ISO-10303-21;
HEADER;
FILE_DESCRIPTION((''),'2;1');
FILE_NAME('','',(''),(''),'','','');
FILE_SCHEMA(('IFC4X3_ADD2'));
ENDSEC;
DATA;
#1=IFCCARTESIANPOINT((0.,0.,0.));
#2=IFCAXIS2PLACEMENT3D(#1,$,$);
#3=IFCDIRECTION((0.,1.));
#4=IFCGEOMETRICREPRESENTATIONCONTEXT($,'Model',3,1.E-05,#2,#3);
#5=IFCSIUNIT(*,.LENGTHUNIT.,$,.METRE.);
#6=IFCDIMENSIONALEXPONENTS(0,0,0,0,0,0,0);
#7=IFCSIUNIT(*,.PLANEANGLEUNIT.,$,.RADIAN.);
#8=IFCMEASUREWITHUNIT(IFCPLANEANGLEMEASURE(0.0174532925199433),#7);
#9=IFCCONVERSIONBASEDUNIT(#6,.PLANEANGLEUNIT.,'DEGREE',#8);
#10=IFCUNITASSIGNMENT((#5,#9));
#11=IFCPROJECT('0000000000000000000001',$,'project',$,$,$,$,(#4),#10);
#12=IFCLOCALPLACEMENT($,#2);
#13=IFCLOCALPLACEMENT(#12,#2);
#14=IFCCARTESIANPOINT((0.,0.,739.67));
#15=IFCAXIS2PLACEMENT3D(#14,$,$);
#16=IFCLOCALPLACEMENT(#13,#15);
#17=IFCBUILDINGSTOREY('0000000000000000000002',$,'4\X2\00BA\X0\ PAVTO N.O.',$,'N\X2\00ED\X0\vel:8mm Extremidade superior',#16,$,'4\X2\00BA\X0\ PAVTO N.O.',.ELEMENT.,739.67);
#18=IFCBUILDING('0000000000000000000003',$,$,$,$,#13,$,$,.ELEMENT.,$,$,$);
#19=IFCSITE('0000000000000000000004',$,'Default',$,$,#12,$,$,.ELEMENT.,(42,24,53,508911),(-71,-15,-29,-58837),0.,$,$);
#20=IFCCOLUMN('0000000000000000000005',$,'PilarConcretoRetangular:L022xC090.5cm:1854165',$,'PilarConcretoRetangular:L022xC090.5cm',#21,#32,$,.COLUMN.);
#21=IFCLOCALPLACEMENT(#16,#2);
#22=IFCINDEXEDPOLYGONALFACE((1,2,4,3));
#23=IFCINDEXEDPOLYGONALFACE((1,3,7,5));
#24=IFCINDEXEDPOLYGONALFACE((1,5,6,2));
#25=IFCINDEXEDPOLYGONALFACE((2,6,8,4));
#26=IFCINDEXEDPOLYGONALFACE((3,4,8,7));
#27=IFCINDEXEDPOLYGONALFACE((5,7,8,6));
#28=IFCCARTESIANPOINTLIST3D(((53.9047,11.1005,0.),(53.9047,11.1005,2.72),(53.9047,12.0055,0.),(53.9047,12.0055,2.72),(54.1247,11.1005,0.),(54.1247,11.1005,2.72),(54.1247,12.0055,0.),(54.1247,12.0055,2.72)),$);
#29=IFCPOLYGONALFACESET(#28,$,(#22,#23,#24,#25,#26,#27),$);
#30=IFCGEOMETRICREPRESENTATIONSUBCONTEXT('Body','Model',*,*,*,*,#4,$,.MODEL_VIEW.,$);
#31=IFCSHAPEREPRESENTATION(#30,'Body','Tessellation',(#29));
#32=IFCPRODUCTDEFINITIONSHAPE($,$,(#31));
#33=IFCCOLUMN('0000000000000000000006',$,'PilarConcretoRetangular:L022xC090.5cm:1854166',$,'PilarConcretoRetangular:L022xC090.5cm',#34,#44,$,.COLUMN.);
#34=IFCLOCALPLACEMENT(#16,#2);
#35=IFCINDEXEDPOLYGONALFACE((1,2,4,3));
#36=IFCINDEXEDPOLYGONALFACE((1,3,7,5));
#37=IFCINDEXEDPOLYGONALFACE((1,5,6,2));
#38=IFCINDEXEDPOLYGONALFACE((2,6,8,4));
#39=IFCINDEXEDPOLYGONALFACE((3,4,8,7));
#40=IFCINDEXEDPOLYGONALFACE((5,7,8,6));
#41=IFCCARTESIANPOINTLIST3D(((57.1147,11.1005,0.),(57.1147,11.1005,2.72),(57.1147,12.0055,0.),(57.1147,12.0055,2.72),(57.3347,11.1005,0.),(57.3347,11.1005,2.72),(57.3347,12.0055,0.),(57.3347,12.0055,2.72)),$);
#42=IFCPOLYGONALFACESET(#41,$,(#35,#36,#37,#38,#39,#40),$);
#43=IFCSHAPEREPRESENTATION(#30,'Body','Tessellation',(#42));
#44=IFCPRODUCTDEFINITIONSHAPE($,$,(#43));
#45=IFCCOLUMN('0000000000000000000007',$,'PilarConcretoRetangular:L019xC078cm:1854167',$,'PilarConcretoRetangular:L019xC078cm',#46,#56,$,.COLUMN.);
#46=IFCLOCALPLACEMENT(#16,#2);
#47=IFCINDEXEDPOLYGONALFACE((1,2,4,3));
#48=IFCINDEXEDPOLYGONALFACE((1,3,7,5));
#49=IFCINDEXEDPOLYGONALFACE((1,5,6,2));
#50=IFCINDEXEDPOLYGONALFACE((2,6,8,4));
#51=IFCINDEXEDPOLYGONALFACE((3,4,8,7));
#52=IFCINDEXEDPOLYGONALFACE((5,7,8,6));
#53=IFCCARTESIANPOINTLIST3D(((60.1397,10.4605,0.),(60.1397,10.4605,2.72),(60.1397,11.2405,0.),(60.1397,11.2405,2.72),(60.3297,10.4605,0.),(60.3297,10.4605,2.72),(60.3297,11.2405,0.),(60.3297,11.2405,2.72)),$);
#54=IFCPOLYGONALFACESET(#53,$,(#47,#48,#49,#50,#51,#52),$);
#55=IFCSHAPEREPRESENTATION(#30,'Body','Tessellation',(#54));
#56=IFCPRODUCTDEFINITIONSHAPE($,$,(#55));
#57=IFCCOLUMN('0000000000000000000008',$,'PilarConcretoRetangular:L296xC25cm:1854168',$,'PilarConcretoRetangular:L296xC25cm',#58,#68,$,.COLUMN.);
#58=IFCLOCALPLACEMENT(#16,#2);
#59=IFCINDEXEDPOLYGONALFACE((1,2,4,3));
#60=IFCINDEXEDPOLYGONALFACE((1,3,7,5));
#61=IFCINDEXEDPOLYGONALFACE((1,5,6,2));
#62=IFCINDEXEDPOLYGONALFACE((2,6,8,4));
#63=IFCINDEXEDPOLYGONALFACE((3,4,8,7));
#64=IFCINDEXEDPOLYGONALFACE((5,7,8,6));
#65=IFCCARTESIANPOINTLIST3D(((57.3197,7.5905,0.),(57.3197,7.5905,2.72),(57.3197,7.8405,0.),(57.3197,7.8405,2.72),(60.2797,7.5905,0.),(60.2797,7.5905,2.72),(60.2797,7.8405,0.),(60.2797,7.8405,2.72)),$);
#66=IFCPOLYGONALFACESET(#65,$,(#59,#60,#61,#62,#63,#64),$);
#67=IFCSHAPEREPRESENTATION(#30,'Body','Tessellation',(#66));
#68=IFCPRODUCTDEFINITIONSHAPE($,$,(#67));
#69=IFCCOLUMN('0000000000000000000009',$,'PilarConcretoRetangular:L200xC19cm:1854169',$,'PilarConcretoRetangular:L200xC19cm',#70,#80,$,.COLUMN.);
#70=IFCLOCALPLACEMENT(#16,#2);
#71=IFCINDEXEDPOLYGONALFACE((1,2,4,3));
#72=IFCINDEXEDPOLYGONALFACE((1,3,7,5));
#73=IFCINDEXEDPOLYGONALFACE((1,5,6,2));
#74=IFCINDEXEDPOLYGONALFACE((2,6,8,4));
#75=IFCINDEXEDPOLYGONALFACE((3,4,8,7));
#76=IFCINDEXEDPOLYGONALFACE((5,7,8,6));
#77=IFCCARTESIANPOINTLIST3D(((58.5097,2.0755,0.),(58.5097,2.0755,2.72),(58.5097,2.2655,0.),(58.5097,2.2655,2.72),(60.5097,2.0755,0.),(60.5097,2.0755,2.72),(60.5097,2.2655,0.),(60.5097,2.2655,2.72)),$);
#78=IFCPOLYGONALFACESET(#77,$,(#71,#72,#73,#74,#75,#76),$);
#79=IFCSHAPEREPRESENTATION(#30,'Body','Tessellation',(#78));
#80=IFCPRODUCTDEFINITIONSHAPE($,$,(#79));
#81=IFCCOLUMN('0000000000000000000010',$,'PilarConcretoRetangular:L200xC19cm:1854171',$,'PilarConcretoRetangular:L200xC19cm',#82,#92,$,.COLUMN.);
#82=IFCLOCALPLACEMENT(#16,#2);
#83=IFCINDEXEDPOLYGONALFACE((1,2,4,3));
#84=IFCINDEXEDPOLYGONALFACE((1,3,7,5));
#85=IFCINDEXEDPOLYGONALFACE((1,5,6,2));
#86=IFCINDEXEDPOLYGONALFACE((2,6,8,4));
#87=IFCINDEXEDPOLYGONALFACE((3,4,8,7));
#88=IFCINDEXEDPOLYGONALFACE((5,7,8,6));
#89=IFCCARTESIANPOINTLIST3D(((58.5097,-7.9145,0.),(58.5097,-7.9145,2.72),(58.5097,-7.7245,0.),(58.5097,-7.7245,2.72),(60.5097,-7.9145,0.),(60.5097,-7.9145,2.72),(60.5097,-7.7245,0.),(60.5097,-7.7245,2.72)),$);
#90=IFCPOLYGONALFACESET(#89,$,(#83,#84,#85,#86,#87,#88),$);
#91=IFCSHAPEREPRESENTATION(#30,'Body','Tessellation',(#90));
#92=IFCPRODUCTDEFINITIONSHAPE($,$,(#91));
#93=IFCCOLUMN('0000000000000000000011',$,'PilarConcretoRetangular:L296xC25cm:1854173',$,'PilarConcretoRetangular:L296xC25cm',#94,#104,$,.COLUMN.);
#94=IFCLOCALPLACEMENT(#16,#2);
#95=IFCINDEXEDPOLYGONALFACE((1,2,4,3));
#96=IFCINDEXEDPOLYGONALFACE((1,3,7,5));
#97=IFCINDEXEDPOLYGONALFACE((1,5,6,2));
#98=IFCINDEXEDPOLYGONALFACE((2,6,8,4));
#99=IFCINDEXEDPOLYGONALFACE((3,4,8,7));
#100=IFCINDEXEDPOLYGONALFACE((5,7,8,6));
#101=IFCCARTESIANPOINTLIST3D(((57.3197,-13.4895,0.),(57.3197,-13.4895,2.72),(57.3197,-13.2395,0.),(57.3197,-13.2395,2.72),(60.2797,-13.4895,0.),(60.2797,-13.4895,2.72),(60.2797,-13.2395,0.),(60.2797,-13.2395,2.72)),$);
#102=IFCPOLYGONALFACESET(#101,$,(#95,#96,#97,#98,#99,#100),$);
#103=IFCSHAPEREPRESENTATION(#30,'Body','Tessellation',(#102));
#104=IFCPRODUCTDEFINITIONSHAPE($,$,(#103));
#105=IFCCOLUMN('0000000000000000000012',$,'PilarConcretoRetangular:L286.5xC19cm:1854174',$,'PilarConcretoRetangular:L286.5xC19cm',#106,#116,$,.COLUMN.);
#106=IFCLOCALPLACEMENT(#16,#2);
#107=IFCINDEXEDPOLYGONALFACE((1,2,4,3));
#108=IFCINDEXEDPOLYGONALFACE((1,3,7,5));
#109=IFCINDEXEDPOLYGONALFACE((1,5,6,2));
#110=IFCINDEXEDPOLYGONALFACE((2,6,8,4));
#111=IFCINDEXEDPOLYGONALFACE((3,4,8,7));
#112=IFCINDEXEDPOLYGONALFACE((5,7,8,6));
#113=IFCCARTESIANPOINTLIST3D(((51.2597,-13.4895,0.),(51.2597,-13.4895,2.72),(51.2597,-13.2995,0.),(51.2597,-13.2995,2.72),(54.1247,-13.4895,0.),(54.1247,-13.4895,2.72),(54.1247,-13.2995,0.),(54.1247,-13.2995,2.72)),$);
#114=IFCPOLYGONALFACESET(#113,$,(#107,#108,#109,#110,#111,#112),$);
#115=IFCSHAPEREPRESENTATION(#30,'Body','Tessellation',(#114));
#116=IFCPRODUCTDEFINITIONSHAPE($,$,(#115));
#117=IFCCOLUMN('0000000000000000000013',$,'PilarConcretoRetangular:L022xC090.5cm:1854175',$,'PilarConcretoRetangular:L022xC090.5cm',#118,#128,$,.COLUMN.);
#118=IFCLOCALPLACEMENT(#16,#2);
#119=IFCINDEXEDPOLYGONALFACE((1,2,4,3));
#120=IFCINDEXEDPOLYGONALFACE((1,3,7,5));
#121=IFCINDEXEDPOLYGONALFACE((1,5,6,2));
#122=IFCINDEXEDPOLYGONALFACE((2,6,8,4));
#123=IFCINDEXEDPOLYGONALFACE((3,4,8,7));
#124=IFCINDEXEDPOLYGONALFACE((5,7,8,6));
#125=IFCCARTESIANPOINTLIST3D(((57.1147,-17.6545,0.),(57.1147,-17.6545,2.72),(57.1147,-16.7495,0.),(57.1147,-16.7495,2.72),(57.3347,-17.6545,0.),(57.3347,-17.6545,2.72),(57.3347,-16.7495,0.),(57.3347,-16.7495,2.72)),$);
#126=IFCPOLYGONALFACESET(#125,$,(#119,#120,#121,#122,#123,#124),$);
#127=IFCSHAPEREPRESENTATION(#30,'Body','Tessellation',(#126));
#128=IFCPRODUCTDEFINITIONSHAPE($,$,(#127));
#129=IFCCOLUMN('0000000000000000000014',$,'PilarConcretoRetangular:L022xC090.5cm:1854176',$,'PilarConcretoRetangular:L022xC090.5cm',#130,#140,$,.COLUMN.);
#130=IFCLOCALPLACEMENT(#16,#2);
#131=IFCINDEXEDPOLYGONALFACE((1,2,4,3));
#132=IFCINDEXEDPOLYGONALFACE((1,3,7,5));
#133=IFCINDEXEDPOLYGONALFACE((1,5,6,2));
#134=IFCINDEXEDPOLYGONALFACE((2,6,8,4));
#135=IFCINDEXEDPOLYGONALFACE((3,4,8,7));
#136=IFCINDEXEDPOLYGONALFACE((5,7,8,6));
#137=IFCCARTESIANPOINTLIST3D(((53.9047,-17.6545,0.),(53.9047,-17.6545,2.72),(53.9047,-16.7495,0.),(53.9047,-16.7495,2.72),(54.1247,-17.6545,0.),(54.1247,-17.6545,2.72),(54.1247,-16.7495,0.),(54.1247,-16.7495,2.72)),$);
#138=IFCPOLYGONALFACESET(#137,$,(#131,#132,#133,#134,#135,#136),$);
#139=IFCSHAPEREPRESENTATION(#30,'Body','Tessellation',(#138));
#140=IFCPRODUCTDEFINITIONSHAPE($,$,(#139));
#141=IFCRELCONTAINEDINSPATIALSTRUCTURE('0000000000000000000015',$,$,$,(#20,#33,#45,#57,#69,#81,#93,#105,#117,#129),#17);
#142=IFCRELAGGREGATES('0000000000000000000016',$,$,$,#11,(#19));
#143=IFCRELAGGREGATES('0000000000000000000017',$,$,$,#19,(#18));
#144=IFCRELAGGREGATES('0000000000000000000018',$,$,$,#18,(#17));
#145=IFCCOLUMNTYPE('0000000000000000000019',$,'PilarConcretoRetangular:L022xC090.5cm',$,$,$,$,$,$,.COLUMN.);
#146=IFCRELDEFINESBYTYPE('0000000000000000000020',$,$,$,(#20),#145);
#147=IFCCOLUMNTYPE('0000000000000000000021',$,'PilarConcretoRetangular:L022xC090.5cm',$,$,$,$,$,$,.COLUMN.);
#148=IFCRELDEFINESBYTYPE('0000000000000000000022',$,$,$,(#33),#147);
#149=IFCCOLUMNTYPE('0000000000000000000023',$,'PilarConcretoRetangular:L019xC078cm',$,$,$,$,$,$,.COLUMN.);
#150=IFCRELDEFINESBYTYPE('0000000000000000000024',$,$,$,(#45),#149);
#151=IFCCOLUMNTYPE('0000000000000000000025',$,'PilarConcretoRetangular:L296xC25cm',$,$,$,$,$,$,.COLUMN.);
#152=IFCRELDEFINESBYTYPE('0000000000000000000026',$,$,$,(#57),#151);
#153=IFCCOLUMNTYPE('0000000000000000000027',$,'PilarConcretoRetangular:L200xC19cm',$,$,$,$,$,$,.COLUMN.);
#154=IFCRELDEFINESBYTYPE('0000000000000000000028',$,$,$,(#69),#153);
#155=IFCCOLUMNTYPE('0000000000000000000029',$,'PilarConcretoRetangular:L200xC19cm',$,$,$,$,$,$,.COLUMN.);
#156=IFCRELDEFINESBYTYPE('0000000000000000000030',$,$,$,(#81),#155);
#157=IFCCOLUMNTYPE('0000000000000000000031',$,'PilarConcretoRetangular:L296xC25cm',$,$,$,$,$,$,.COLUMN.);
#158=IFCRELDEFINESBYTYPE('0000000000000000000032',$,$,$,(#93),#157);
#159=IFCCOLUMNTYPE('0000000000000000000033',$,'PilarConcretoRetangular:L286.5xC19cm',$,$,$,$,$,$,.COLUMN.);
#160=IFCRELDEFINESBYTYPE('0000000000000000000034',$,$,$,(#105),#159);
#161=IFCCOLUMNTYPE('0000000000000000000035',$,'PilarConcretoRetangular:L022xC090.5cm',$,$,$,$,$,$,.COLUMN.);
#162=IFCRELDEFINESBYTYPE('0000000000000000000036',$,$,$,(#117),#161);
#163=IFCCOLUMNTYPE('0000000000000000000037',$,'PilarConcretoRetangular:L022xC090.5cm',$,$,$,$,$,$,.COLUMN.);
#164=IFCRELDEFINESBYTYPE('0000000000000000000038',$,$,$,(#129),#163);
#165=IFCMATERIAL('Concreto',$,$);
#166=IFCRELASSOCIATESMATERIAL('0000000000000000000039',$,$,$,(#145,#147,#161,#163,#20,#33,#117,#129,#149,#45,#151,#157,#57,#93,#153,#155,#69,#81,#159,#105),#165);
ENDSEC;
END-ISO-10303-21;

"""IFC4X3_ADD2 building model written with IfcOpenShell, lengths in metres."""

from ifc_helpers import new_model, entity, si_unit, converted_unit, direction, frame, frame_2d, origin, origin_2d_with_axis, place, context, subcontext, project, spatial, rectangle, extrude, source, transform, mapped, material, material_profile, profile_set, profile_usage, type_object, type_shapes, element, save


model = new_model("IFC4X3_ADD2")

# Units and contexts
model_context = context("Model", 3, precision=1e-05, world=origin(), true_north=direction((0.0, 1.0)))
body_context = subcontext(model_context, "Body", "Model", "MODEL_VIEW")
ifc_project = project(units=[si_unit("LENGTHUNIT", "METRE"), converted_unit("PLANEANGLEUNIT", "DEGREE", entity("IfcPlaneAngleMeasure", 0.0174532925199433), si_unit("PLANEANGLEUNIT", "RADIAN"), dimensions=[0, 0, 0, 0, 0, 0, 0])], contexts=[model_context])

# Site, building, storey
site_placement = place(None, origin())
site = spatial("IfcSite", under=ifc_project, at=site_placement, Name="Default", CompositionType="ELEMENT", RefLatitude=(42, 24, 53, 508911), RefLongitude=(-71, -15, -29, -58837), RefElevation=0.0)
building_placement = place(site_placement, origin())
building = spatial("IfcBuilding", under=site, at=building_placement, CompositionType="ELEMENT")
storey_placement = place(building_placement, frame((0.0, 0.0, 739.67)))
storey = spatial("IfcBuildingStorey", under=building, at=storey_placement, Name="4º PAVTO N.O.", ObjectType="Nível:8mm Extremidade superior", LongName="4º PAVTO N.O.", CompositionType="ELEMENT", Elevation=739.67)

# Columns
ifc_material = material(Name="Concreto")
ifc_material_profile_1 = material_profile(ifc_material, rectangle(XDim=0.22, YDim=0.905, at=frame_2d((0.0, 0.0), x_axis=(1.0, 0.0))), Name="L022xC090.5cm")
ifc_profile_set_1 = profile_set([ifc_material_profile_1], Name="L022xC090.5cm")
ifc_profile_usage_1 = profile_usage(ifc_profile_set_1)
ifc_material_profile_2 = material_profile(ifc_material, rectangle(XDim=2.0, YDim=0.19, at=frame_2d((0.0, 0.0), x_axis=(1.0, 0.0))), Name="L200xC19cm")
ifc_profile_set_2 = profile_set([ifc_material_profile_2], Name="L200xC19cm")
ifc_profile_usage_2 = profile_usage(ifc_profile_set_2)
ifc_material_profile_3 = material_profile(ifc_material, rectangle(XDim=2.96, YDim=0.25, at=frame_2d((0.0, 0.0), x_axis=(1.0, 0.0))), Name="L296xC25cm")
ifc_profile_set_3 = profile_set([ifc_material_profile_3], Name="L296xC25cm")
ifc_profile_usage_3 = profile_usage(ifc_profile_set_3)
ifc_material_profile_4 = material_profile(ifc_material, rectangle(XDim=2.865, YDim=0.19, at=frame_2d((0.0, 0.0), x_axis=(1.0, 0.0))), Name="L286.5xC19cm")
ifc_profile_set_4 = profile_set([ifc_material_profile_4], Name="L286.5xC19cm")
ifc_profile_usage_4 = profile_usage(ifc_profile_set_4)
column_type_1 = type_object("IfcColumnType", Name="PilarConcretoRetangular:L022xC090.5cm", PredefinedType="COLUMN", material=ifc_profile_set_1)
shared_shape_1 = source(origin(), body_context, "Body", "SweptSolid", [
    extrude(rectangle(XDim=0.22, YDim=0.905, at=frame_2d((0.0, 0.0), x_axis=(1.0, 0.0))), frame((54.0147, 11.553, 739.67)), (0.0, 0.0, 1.0), 2.72),
])
type_shapes(column_type_1, [shared_shape_1])
column_1_placement = place(storey_placement, frame((0.0, 0.0, -739.67)))
element("IfcColumn", 1, at=column_1_placement, inside=storey, type_object=column_type_1, material=ifc_profile_usage_1, Name="PilarConcretoRetangular:L022xC090.5cm:1854165", ObjectType="PilarConcretoRetangular:L022xC090.5cm", PredefinedType="COLUMN", context=body_context, shape_type="MappedRepresentation", body=[
    mapped(shared_shape_1, transform((0.0, 0.0, 0.0), scale=1.0)),
])
column_type_2 = type_object("IfcColumnType", Name="PilarConcretoRetangular:L022xC090.5cm", PredefinedType="COLUMN", material=ifc_profile_set_1)
shared_shape_2 = source(origin(), body_context, "Body", "SweptSolid", [
    extrude(rectangle(XDim=0.22, YDim=0.905, at=frame_2d((0.0, 0.0), x_axis=(1.0, 0.0))), frame((57.2247, 11.553, 739.67)), (0.0, 0.0, 1.0), 2.72),
])
type_shapes(column_type_2, [shared_shape_2])
column_2_placement = place(storey_placement, frame((0.0, 0.0, -739.67)))
element("IfcColumn", 2, at=column_2_placement, inside=storey, type_object=column_type_2, material=ifc_profile_usage_1, Name="PilarConcretoRetangular:L022xC090.5cm:1854166", ObjectType="PilarConcretoRetangular:L022xC090.5cm", PredefinedType="COLUMN", context=body_context, shape_type="MappedRepresentation", body=[
    mapped(shared_shape_2, transform((0.0, 0.0, 0.0), scale=1.0)),
])
ifc_material_profile_5 = material_profile(ifc_material, rectangle(XDim=0.19, YDim=0.78, at=frame_2d((0.0, 0.0), x_axis=(1.0, 0.0))), Name="L019xC078cm")
ifc_profile_set_5 = profile_set([ifc_material_profile_5], Name="L019xC078cm")
ifc_profile_usage_5 = profile_usage(ifc_profile_set_5)
column_type_3 = type_object("IfcColumnType", Name="PilarConcretoRetangular:L019xC078cm", PredefinedType="COLUMN", material=ifc_profile_set_5)
shared_shape_3 = source(origin(), body_context, "Body", "SweptSolid", [
    extrude(rectangle(XDim=0.19, YDim=0.78, at=frame_2d((0.0, 0.0), x_axis=(1.0, 0.0))), frame((60.2347, 10.8505, 739.67)), (0.0, 0.0, 1.0), 2.72),
])
type_shapes(column_type_3, [shared_shape_3])
column_3_placement = place(storey_placement, frame((0.0, 0.0, -739.67)))
element("IfcColumn", 3, at=column_3_placement, inside=storey, type_object=column_type_3, material=ifc_profile_usage_5, Name="PilarConcretoRetangular:L019xC078cm:1854167", ObjectType="PilarConcretoRetangular:L019xC078cm", PredefinedType="COLUMN", context=body_context, shape_type="MappedRepresentation", body=[
    mapped(shared_shape_3, transform((0.0, 0.0, 0.0), scale=1.0)),
])
column_type_4 = type_object("IfcColumnType", Name="PilarConcretoRetangular:L296xC25cm", PredefinedType="COLUMN", material=ifc_profile_set_3)
shared_shape_4 = source(origin(), body_context, "Body", "SweptSolid", [
    extrude(rectangle(XDim=2.96, YDim=0.25, at=frame_2d((0.0, 0.0), x_axis=(1.0, 0.0))), frame((58.7997, 7.7155, 739.67), z_axis=(0.0, 0.0, 1.0), x_axis=(-1.0, 0.0, 0.0)), (0.0, 0.0, 1.0), 2.72),
])
type_shapes(column_type_4, [shared_shape_4])
column_4_placement = place(storey_placement, frame((0.0, 0.0, -739.67)))
element("IfcColumn", 4, at=column_4_placement, inside=storey, type_object=column_type_4, material=ifc_profile_usage_3, Name="PilarConcretoRetangular:L296xC25cm:1854168", ObjectType="PilarConcretoRetangular:L296xC25cm", PredefinedType="COLUMN", context=body_context, shape_type="MappedRepresentation", body=[
    mapped(shared_shape_4, transform((0.0, 0.0, 0.0), scale=1.0)),
])
column_type_5 = type_object("IfcColumnType", Name="PilarConcretoRetangular:L200xC19cm", PredefinedType="COLUMN", material=ifc_profile_set_2)
shared_shape_5 = source(origin(), body_context, "Body", "SweptSolid", [
    extrude(rectangle(XDim=2.0, YDim=0.19, at=origin_2d_with_axis()), frame((59.5097, 2.1705, 739.67), z_axis=(0.0, 0.0, 1.0), x_axis=(-1.0, 0.0, 0.0)), (0.0, 0.0, 1.0), 2.72),
])
type_shapes(column_type_5, [shared_shape_5])
column_5_placement = place(storey_placement, frame((0.0, 0.0, -739.67)))
element("IfcColumn", 5, at=column_5_placement, inside=storey, type_object=column_type_5, material=ifc_profile_usage_2, Name="PilarConcretoRetangular:L200xC19cm:1854169", ObjectType="PilarConcretoRetangular:L200xC19cm", PredefinedType="COLUMN", context=body_context, shape_type="MappedRepresentation", body=[
    mapped(shared_shape_5, transform((0.0, 0.0, 0.0), scale=1.0)),
])
column_type_6 = type_object("IfcColumnType", Name="PilarConcretoRetangular:L200xC19cm", PredefinedType="COLUMN", material=ifc_profile_set_2)
shared_shape_6 = source(origin(), body_context, "Body", "SweptSolid", [
    extrude(rectangle(XDim=2.0, YDim=0.19, at=origin_2d_with_axis()), frame((59.5097, -7.8195, 739.67), z_axis=(0.0, 0.0, 1.0), x_axis=(-1.0, 0.0, 0.0)), (0.0, 0.0, 1.0), 2.72),
])
type_shapes(column_type_6, [shared_shape_6])
column_6_placement = place(storey_placement, frame((0.0, 0.0, -739.67)))
element("IfcColumn", 6, at=column_6_placement, inside=storey, type_object=column_type_6, material=ifc_profile_usage_2, Name="PilarConcretoRetangular:L200xC19cm:1854171", ObjectType="PilarConcretoRetangular:L200xC19cm", PredefinedType="COLUMN", context=body_context, shape_type="MappedRepresentation", body=[
    mapped(shared_shape_6, transform((0.0, 0.0, 0.0), scale=1.0)),
])
column_type_7 = type_object("IfcColumnType", Name="PilarConcretoRetangular:L296xC25cm", PredefinedType="COLUMN", material=ifc_profile_set_3)
shared_shape_7 = source(origin(), body_context, "Body", "SweptSolid", [
    extrude(rectangle(XDim=2.96, YDim=0.25, at=frame_2d((0.0, 0.0), x_axis=(1.0, 0.0))), frame((58.7997, -13.3645, 739.67), z_axis=(0.0, 0.0, 1.0), x_axis=(-1.0, 0.0, 0.0)), (0.0, 0.0, 1.0), 2.72),
])
type_shapes(column_type_7, [shared_shape_7])
column_7_placement = place(storey_placement, frame((0.0, 0.0, -739.67)))
element("IfcColumn", 7, at=column_7_placement, inside=storey, type_object=column_type_7, material=ifc_profile_usage_3, Name="PilarConcretoRetangular:L296xC25cm:1854173", ObjectType="PilarConcretoRetangular:L296xC25cm", PredefinedType="COLUMN", context=body_context, shape_type="MappedRepresentation", body=[
    mapped(shared_shape_7, transform((0.0, 0.0, 0.0), scale=1.0)),
])
column_type_8 = type_object("IfcColumnType", Name="PilarConcretoRetangular:L286.5xC19cm", PredefinedType="COLUMN", material=ifc_profile_set_4)
shared_shape_8 = source(origin(), body_context, "Body", "SweptSolid", [
    extrude(rectangle(XDim=2.865, YDim=0.19, at=frame_2d((0.0, 0.0), x_axis=(1.0, 0.0))), frame((52.6922, -13.3945, 739.67), z_axis=(0.0, 0.0, 1.0), x_axis=(-1.0, 0.0, 0.0)), (0.0, 0.0, 1.0), 2.72),
])
type_shapes(column_type_8, [shared_shape_8])
column_8_placement = place(storey_placement, frame((0.0, 0.0, -739.67)))
element("IfcColumn", 8, at=column_8_placement, inside=storey, type_object=column_type_8, material=ifc_profile_usage_4, Name="PilarConcretoRetangular:L286.5xC19cm:1854174", ObjectType="PilarConcretoRetangular:L286.5xC19cm", PredefinedType="COLUMN", context=body_context, shape_type="MappedRepresentation", body=[
    mapped(shared_shape_8, transform((0.0, 0.0, 0.0), scale=1.0)),
])
column_type_9 = type_object("IfcColumnType", Name="PilarConcretoRetangular:L022xC090.5cm", PredefinedType="COLUMN", material=ifc_profile_set_1)
shared_shape_9 = source(origin(), body_context, "Body", "SweptSolid", [
    extrude(rectangle(XDim=0.22, YDim=0.905, at=frame_2d((0.0, 0.0), x_axis=(1.0, 0.0))), frame((57.2247, -17.202, 739.67), z_axis=(0.0, 0.0, 1.0), x_axis=(-1.0, 0.0, 0.0)), (0.0, 0.0, 1.0), 2.72),
])
type_shapes(column_type_9, [shared_shape_9])
column_9_placement = place(storey_placement, frame((0.0, 0.0, -739.67)))
element("IfcColumn", 9, at=column_9_placement, inside=storey, type_object=column_type_9, material=ifc_profile_usage_1, Name="PilarConcretoRetangular:L022xC090.5cm:1854175", ObjectType="PilarConcretoRetangular:L022xC090.5cm", PredefinedType="COLUMN", context=body_context, shape_type="MappedRepresentation", body=[
    mapped(shared_shape_9, transform((0.0, 0.0, 0.0), scale=1.0)),
])
column_type_10 = type_object("IfcColumnType", Name="PilarConcretoRetangular:L022xC090.5cm", PredefinedType="COLUMN", material=ifc_profile_set_1)
shared_shape_10 = source(origin(), body_context, "Body", "SweptSolid", [
    extrude(rectangle(XDim=0.22, YDim=0.905, at=frame_2d((0.0, 0.0), x_axis=(1.0, 0.0))), frame((54.0147, -17.202, 739.67), z_axis=(0.0, 0.0, 1.0), x_axis=(-1.0, 0.0, 0.0)), (0.0, 0.0, 1.0), 2.72),
])
type_shapes(column_type_10, [shared_shape_10])
column_10_placement = place(storey_placement, frame((0.0, 0.0, -739.67)))
element("IfcColumn", 10, at=column_10_placement, inside=storey, type_object=column_type_10, material=ifc_profile_usage_1, Name="PilarConcretoRetangular:L022xC090.5cm:1854176", ObjectType="PilarConcretoRetangular:L022xC090.5cm", PredefinedType="COLUMN", context=body_context, shape_type="MappedRepresentation", body=[
    mapped(shared_shape_10, transform((0.0, 0.0, 0.0), scale=1.0)),
])

save(model, "model.ifc")
